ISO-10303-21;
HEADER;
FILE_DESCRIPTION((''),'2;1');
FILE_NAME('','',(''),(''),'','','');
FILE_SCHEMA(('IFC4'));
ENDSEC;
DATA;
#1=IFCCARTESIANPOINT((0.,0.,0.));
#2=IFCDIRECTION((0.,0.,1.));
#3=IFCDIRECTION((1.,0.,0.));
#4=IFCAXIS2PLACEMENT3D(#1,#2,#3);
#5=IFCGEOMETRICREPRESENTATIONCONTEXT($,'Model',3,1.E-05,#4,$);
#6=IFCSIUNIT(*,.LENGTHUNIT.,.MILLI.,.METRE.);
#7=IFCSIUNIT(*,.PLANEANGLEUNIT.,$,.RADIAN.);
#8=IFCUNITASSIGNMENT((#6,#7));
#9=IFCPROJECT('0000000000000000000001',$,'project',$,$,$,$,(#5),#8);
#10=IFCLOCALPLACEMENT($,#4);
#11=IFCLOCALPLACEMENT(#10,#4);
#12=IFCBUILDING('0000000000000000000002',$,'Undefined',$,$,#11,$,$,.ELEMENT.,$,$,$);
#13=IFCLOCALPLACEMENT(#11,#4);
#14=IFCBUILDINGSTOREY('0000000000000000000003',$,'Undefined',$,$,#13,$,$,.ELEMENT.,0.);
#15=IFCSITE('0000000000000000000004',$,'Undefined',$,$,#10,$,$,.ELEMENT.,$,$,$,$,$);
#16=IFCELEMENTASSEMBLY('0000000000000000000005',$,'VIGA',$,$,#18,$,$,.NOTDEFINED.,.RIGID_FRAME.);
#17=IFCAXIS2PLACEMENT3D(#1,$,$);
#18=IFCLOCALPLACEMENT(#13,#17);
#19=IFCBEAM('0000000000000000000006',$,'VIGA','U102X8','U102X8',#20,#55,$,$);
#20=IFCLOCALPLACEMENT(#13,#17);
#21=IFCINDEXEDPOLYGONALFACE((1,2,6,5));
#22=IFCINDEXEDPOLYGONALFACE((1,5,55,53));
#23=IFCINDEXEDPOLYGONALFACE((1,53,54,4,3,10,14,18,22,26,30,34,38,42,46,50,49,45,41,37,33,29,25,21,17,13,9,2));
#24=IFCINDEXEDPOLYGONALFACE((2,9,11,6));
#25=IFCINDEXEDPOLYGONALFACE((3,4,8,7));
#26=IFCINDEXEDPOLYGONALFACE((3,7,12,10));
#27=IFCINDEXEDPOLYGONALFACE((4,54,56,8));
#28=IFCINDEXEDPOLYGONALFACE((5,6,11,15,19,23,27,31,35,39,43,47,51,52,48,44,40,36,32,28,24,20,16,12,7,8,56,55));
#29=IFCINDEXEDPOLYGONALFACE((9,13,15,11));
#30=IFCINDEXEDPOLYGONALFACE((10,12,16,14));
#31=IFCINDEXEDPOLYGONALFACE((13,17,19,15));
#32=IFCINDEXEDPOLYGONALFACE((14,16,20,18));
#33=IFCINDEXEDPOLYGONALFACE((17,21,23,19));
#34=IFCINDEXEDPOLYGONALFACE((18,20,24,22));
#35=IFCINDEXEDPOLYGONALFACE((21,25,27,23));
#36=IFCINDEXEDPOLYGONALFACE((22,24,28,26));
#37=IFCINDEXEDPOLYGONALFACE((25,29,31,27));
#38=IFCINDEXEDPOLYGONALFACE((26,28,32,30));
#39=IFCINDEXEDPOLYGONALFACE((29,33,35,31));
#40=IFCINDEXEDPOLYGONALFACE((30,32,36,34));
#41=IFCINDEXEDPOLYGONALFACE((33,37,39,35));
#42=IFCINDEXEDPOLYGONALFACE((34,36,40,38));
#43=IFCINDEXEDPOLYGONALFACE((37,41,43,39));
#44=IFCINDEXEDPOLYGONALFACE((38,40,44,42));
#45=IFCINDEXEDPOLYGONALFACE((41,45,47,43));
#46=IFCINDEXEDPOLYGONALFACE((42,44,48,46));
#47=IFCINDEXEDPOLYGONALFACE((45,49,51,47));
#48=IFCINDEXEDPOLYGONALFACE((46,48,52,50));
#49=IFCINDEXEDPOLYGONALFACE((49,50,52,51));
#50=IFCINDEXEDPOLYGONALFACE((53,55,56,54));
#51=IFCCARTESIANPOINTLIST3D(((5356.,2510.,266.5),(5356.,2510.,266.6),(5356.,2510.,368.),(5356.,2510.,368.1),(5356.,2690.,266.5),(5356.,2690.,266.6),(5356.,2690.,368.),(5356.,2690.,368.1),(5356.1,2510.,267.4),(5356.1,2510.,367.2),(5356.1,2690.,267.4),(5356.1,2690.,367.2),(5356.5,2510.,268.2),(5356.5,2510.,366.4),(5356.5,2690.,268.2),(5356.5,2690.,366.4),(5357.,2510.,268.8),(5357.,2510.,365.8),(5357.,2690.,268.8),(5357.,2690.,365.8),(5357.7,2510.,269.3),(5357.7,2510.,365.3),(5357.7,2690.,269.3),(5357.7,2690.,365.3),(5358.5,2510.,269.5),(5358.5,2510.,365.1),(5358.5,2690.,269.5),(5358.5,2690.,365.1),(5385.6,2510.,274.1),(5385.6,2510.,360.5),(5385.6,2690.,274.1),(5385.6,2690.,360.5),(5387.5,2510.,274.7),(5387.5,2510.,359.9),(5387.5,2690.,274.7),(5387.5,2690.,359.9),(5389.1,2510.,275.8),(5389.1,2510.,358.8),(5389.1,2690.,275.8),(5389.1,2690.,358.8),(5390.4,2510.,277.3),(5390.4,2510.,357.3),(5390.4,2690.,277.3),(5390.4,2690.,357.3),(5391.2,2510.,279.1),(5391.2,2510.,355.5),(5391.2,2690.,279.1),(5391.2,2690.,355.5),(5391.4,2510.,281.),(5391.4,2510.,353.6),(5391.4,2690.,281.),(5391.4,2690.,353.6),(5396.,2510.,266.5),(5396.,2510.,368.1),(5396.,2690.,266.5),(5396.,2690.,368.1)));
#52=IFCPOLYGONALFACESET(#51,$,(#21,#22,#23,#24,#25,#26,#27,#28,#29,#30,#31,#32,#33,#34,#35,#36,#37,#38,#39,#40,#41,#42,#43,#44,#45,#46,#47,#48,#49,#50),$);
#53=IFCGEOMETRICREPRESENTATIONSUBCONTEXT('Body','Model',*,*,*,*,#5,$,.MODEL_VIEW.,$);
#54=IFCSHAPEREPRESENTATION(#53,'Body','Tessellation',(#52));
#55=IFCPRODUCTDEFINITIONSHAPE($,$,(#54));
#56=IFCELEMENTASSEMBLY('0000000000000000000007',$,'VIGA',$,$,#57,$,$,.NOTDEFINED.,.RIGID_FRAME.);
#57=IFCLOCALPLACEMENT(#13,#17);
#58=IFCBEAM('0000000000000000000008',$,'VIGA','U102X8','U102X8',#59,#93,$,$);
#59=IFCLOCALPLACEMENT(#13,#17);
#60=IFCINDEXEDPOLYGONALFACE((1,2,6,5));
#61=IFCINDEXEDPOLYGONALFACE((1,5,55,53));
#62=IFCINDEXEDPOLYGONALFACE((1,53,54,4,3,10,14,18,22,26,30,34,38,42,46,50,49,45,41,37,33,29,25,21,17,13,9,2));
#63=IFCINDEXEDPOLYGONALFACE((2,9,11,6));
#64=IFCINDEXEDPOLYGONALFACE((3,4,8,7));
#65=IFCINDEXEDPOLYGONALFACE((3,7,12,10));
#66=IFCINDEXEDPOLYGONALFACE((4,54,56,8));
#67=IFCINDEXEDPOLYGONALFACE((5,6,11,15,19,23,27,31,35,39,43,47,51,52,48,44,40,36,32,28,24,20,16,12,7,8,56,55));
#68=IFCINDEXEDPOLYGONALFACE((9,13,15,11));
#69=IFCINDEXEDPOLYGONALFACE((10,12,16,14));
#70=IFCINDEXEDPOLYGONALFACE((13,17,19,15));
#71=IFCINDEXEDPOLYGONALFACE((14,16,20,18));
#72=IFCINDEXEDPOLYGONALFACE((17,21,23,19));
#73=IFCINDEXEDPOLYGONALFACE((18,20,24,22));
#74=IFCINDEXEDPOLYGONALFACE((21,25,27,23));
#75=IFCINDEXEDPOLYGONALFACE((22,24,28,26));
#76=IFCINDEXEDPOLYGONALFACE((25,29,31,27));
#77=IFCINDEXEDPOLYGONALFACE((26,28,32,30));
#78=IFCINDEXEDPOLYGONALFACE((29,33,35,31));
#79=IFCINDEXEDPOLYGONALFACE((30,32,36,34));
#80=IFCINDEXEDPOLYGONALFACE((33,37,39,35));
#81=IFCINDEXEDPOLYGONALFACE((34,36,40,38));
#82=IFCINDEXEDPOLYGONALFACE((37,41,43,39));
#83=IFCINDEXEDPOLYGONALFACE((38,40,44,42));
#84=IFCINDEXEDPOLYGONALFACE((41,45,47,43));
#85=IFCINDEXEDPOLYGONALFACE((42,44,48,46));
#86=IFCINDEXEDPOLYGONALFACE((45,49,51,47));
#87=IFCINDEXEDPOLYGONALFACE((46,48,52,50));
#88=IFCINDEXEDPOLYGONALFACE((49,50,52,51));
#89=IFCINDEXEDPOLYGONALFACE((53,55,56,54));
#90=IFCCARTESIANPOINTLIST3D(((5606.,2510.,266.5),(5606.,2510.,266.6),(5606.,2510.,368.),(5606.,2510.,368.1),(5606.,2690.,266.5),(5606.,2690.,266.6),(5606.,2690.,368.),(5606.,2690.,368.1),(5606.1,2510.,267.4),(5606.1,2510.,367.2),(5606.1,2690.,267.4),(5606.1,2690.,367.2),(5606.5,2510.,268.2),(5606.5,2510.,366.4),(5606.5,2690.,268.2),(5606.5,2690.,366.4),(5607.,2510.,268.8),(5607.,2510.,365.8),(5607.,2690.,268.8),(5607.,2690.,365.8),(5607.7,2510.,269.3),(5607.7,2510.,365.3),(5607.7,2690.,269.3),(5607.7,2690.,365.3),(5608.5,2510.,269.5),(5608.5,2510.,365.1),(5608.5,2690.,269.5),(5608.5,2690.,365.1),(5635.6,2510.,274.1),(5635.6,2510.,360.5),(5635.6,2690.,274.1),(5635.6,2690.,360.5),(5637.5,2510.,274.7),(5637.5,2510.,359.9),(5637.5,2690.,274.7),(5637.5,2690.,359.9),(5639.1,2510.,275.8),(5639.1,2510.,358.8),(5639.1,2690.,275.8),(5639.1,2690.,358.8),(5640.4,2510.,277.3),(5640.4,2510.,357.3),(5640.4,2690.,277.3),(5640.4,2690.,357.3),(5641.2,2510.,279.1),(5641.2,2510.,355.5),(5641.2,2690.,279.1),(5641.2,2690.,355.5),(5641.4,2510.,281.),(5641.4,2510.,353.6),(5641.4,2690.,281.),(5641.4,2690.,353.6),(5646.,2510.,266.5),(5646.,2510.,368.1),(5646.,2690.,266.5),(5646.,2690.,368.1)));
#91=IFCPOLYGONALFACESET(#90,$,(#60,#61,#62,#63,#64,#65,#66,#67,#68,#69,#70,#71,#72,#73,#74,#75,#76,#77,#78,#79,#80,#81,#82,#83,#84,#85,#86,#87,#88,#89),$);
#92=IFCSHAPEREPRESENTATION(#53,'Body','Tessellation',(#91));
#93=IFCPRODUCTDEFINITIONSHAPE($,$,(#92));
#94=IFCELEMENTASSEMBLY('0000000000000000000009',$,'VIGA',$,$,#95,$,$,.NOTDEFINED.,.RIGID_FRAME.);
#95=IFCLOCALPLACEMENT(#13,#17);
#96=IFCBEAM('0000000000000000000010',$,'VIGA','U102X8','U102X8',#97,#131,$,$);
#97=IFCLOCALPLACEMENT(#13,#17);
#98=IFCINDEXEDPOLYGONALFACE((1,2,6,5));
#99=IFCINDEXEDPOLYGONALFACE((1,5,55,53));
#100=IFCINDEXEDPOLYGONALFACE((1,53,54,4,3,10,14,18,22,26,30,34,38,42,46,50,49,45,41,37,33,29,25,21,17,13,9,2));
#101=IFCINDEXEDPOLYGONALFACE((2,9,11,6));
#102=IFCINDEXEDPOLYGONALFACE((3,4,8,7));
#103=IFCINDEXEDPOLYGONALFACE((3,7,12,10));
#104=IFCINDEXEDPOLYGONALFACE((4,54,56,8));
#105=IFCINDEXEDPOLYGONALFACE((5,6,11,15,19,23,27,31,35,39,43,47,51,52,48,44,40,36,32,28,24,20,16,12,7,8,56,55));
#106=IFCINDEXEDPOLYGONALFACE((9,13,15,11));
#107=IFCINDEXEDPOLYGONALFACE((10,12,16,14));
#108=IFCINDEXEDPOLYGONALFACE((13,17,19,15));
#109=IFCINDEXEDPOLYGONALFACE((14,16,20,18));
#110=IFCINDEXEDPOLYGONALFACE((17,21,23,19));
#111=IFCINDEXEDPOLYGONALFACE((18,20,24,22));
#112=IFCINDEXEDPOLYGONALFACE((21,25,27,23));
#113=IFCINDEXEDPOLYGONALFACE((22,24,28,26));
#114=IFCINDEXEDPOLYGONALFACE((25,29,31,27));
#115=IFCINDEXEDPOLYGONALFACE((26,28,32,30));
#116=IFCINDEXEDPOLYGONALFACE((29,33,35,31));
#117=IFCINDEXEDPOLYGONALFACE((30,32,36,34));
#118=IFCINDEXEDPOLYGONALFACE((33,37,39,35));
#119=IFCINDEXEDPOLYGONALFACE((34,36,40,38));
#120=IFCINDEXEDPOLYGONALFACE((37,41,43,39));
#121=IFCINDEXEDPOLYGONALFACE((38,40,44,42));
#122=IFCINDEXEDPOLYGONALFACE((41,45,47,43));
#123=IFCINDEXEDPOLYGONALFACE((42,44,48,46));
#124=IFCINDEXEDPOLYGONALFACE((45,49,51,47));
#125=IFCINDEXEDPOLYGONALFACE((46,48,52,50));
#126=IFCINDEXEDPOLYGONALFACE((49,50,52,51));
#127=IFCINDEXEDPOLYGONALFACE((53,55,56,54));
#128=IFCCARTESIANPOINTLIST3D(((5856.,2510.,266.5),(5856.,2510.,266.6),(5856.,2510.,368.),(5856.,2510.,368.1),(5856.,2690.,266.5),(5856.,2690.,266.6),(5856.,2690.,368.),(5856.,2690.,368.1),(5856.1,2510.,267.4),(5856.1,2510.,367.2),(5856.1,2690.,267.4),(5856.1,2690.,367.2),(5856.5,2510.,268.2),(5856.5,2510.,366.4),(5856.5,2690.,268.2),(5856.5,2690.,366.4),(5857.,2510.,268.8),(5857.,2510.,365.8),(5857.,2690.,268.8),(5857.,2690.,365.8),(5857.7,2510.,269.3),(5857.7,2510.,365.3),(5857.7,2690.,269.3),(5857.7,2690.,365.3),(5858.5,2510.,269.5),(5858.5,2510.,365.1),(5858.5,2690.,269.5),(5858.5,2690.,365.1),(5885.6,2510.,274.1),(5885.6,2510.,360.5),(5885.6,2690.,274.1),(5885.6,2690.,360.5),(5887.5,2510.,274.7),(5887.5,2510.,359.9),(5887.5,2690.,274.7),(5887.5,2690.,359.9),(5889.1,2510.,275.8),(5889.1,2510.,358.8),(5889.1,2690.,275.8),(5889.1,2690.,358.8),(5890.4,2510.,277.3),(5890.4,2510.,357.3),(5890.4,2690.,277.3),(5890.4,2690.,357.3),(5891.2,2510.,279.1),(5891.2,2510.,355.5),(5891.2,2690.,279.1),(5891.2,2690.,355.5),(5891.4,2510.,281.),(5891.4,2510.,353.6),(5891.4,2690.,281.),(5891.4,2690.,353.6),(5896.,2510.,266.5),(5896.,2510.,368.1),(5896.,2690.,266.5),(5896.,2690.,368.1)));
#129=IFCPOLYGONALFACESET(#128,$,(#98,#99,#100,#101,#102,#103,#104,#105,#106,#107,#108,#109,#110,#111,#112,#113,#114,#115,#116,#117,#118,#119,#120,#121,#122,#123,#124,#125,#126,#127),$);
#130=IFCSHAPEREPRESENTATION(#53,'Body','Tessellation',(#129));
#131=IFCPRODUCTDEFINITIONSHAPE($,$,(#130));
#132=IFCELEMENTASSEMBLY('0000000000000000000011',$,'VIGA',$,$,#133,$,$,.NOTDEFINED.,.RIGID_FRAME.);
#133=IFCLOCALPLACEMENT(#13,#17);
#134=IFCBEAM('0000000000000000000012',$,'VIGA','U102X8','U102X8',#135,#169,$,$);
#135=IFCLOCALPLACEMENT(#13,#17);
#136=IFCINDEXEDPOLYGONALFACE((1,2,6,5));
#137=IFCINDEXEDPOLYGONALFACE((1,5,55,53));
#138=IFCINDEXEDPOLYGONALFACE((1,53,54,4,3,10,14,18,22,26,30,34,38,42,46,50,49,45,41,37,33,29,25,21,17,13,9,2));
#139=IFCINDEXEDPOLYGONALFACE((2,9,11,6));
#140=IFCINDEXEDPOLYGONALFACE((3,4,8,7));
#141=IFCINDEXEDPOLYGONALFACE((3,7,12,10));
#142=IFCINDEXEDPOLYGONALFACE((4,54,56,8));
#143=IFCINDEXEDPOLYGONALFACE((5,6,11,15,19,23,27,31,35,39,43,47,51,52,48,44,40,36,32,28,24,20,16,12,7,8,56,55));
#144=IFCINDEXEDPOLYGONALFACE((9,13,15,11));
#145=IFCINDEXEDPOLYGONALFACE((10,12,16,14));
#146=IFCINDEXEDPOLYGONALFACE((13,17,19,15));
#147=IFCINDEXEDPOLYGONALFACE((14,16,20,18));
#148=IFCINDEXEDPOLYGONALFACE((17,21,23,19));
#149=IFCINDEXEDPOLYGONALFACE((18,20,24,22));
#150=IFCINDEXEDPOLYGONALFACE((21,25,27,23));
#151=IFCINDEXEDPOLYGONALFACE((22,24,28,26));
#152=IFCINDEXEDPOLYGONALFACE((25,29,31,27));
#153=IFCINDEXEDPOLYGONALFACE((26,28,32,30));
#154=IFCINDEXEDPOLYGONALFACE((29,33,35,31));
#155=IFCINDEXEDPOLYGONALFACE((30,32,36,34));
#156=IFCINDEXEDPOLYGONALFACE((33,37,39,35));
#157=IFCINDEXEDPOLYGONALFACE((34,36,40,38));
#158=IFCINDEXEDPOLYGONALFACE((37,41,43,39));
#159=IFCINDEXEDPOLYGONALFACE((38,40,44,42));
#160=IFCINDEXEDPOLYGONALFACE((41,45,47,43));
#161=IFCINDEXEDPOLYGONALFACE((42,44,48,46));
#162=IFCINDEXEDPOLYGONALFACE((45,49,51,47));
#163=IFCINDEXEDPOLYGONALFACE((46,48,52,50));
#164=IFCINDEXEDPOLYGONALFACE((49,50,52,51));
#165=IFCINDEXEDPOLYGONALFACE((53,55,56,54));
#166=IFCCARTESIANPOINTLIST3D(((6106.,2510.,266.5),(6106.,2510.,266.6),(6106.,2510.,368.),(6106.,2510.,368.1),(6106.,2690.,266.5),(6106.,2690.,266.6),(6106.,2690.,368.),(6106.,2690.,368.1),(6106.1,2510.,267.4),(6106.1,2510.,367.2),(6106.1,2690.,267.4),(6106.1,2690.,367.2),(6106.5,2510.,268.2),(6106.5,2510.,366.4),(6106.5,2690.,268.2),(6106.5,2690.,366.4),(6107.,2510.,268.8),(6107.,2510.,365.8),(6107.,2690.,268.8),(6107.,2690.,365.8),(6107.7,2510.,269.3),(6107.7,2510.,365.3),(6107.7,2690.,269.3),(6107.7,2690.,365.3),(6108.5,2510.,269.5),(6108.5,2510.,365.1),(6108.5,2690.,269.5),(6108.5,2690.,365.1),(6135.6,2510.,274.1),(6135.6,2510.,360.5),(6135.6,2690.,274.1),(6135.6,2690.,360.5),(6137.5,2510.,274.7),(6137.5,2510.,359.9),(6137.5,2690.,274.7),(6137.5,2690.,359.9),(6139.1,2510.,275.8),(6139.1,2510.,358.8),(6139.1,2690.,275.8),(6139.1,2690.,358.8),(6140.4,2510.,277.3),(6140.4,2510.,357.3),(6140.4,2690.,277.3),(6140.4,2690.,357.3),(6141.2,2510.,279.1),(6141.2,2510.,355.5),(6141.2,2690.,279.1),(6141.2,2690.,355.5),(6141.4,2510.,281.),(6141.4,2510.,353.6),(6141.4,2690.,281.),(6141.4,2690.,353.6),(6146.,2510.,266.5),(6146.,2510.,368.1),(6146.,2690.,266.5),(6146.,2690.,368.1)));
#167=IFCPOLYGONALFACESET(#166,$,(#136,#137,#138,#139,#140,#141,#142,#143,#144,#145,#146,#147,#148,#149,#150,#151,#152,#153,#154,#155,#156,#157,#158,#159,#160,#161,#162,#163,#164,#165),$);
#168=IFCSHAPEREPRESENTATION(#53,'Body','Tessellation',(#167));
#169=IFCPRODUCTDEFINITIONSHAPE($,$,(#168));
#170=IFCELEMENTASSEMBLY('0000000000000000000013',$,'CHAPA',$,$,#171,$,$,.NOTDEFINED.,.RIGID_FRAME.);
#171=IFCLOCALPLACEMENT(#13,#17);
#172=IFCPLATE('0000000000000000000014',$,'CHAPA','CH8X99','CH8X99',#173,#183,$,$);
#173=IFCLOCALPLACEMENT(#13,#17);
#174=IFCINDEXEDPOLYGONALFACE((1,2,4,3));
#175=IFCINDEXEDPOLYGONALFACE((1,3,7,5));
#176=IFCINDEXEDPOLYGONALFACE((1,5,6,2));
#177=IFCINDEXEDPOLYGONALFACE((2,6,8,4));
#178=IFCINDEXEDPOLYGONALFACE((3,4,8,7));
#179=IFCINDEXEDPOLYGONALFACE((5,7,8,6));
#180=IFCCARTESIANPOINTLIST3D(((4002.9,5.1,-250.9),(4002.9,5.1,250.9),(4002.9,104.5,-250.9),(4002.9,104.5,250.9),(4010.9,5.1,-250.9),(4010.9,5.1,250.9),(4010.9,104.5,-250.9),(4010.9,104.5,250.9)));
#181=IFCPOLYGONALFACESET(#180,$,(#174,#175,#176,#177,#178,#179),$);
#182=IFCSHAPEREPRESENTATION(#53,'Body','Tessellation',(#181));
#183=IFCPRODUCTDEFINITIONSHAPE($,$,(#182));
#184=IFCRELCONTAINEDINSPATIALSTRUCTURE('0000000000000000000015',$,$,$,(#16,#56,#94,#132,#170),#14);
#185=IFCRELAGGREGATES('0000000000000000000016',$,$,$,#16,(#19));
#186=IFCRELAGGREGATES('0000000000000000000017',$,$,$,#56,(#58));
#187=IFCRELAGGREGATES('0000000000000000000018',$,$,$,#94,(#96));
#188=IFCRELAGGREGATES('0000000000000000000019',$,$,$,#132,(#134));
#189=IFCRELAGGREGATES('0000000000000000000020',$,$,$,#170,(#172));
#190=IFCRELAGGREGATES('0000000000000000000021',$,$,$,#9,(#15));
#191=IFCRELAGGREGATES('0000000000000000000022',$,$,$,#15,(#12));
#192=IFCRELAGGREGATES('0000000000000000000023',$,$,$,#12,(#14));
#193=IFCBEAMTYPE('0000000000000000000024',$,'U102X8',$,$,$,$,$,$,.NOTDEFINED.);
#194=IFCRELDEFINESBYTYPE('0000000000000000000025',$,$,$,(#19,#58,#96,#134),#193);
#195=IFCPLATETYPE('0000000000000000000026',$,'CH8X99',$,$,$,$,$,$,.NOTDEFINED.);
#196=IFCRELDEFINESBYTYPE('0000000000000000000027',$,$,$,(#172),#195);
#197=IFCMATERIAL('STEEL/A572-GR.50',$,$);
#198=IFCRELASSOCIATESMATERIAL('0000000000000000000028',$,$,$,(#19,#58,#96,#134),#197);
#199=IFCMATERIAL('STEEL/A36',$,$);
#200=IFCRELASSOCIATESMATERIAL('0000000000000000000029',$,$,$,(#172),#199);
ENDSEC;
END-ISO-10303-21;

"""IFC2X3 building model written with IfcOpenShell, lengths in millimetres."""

from ifc_helpers import new_model, si_unit, frame, origin_with_axes, origin_2d_with_axis, place, context, subcontext, project, spatial, polyline, u_section, outline, extrude, material, type_object, element, aggregate, save


model = new_model("IFC2X3")

# Units and contexts
model_context = context("Model", 3, precision=1e-05, world=origin_with_axes())
body_context = subcontext(model_context, "Body", "Model", "MODEL_VIEW")
ifc_project = project(units=[si_unit("LENGTHUNIT", "METRE", prefix="MILLI"), si_unit("PLANEANGLEUNIT", "RADIAN")], contexts=[model_context])

# Site, building, storey
site_placement = place(None, origin_with_axes())
site = spatial("IfcSite", under=ifc_project, at=site_placement, Name="Undefined", CompositionType="ELEMENT")
building_placement = place(site_placement, origin_with_axes())
building = spatial("IfcBuilding", under=site, at=building_placement, Name="Undefined", CompositionType="ELEMENT")
storey_placement = place(building_placement, origin_with_axes())
storey = spatial("IfcBuildingStorey", under=building, at=storey_placement, Name="Undefined", CompositionType="ELEMENT", Elevation=0.0)

# Element assemblies, beams
ifc_material_1 = material(Name="STEEL/A572-GR.50")
beam_type = type_object("IfcBeamType", Name="U102X8", PredefinedType="NOTDEFINED")
assembly_1_placement = place(storey_placement, origin_with_axes())
assembly_1 = element("IfcElementAssembly", 1, at=assembly_1_placement, inside=storey, Name="VIGA", AssemblyPlace="NOTDEFINED", PredefinedType="RIGID_FRAME")
beam_1_placement = place(assembly_1_placement, frame((5376.0, 2690.0, 317.3), z_axis=(0.0, 0.0, 1.0), x_axis=(0.0, -1.0, 0.0)))
beam_1 = element("IfcBeam", 2, at=beam_1_placement, type_object=beam_type, material=ifc_material_1, Name="VIGA", Description="U102X8", ObjectType="U102X8", context=body_context, shape_type="SweptSolid", body=[
    extrude(u_section(Depth=101.6, FlangeWidth=40.0, WebThickness=4.6, FlangeThickness=6.0, FilletRadius=7.0, EdgeRadius=3.0, FlangeSlope=0.16839, at=origin_2d_with_axis()), frame((180.0, 0.0, 0.0), z_axis=(-1.0, 0.0, 0.0), x_axis=(0.0, -1.0, 0.0)), (0.0, 0.0, 1.0), 180.0),
])
aggregate(assembly_1, [beam_1])
assembly_2_placement = place(storey_placement, origin_with_axes())
assembly_2 = element("IfcElementAssembly", 3, at=assembly_2_placement, inside=storey, Name="VIGA", AssemblyPlace="NOTDEFINED", PredefinedType="RIGID_FRAME")
beam_2_placement = place(assembly_2_placement, frame((5626.0, 2690.0, 317.3), z_axis=(0.0, 0.0, 1.0), x_axis=(0.0, -1.0, 0.0)))
beam_2 = element("IfcBeam", 4, at=beam_2_placement, type_object=beam_type, material=ifc_material_1, Name="VIGA", Description="U102X8", ObjectType="U102X8", context=body_context, shape_type="SweptSolid", body=[
    extrude(u_section(Depth=101.6, FlangeWidth=40.0, WebThickness=4.6, FlangeThickness=6.0, FilletRadius=7.0, EdgeRadius=3.0, FlangeSlope=0.16839, at=origin_2d_with_axis()), frame((180.0, 0.0, 0.0), z_axis=(-1.0, 0.0, 0.0), x_axis=(0.0, -1.0, 0.0)), (0.0, 0.0, 1.0), 180.0),
])
aggregate(assembly_2, [beam_2])
assembly_3_placement = place(storey_placement, origin_with_axes())
assembly_3 = element("IfcElementAssembly", 5, at=assembly_3_placement, inside=storey, Name="VIGA", AssemblyPlace="NOTDEFINED", PredefinedType="RIGID_FRAME")
beam_3_placement = place(assembly_3_placement, frame((5876.0, 2690.0, 317.3), z_axis=(0.0, 0.0, 1.0), x_axis=(0.0, -1.0, 0.0)))
beam_3 = element("IfcBeam", 6, at=beam_3_placement, type_object=beam_type, material=ifc_material_1, Name="VIGA", Description="U102X8", ObjectType="U102X8", context=body_context, shape_type="SweptSolid", body=[
    extrude(u_section(Depth=101.6, FlangeWidth=40.0, WebThickness=4.6, FlangeThickness=6.0, FilletRadius=7.0, EdgeRadius=3.0, FlangeSlope=0.16839, at=origin_2d_with_axis()), frame((180.0, 0.0, 0.0), z_axis=(-1.0, 0.0, 0.0), x_axis=(0.0, -1.0, 0.0)), (0.0, 0.0, 1.0), 180.0),
])
aggregate(assembly_3, [beam_3])
assembly_4_placement = place(storey_placement, origin_with_axes())
assembly_4 = element("IfcElementAssembly", 7, at=assembly_4_placement, inside=storey, Name="VIGA", AssemblyPlace="NOTDEFINED", PredefinedType="RIGID_FRAME")
beam_4_placement = place(assembly_4_placement, frame((6126.0, 2690.0, 317.3), z_axis=(0.0, 0.0, 1.0), x_axis=(0.0, -1.0, 0.0)))
beam_4 = element("IfcBeam", 8, at=beam_4_placement, type_object=beam_type, material=ifc_material_1, Name="VIGA", Description="U102X8", ObjectType="U102X8", context=body_context, shape_type="SweptSolid", body=[
    extrude(u_section(Depth=101.6, FlangeWidth=40.0, WebThickness=4.6, FlangeThickness=6.0, FilletRadius=7.0, EdgeRadius=3.0, FlangeSlope=0.16839, at=origin_2d_with_axis()), frame((180.0, 0.0, 0.0), z_axis=(-1.0, 0.0, 0.0), x_axis=(0.0, -1.0, 0.0)), (0.0, 0.0, 1.0), 180.0),
])
aggregate(assembly_4, [beam_4])

# Element assembly, plate
assembly_5_placement = place(storey_placement, origin_with_axes())
assembly_5 = element("IfcElementAssembly", 9, at=assembly_5_placement, inside=storey, Name="CHAPA", AssemblyPlace="NOTDEFINED", PredefinedType="RIGID_FRAME")
ifc_material_2 = material(Name="STEEL/A36")
plate_type = type_object("IfcPlateType", Name="CH8X99", PredefinedType="NOTDEFINED")
plate_placement = place(assembly_5_placement, frame((4006.9, 5.1, 250.9), z_axis=(-1.0, 0.0, 0.0), x_axis=(0.0, 1.0, 0.0)))
plate = element("IfcPlate", 10, at=plate_placement, type_object=plate_type, material=ifc_material_2, Name="CHAPA", Description="CH8X99", ObjectType="CH8X99", context=body_context, shape_type="SweptSolid", body=[
    extrude(outline(polyline([(0.0, 0.0), (99.4, 0.0), (99.4, 501.8), (0.0, 501.8), (0.0, 0.0)])), frame((0.0, 0.0, -4.0), z_axis=(0.0, 0.0, 1.0), x_axis=(1.0, 0.0, 0.0)), (0.0, 0.0, 1.0), 8.0),
])
aggregate(assembly_5, [plate])

save(model, "model.ifc")
